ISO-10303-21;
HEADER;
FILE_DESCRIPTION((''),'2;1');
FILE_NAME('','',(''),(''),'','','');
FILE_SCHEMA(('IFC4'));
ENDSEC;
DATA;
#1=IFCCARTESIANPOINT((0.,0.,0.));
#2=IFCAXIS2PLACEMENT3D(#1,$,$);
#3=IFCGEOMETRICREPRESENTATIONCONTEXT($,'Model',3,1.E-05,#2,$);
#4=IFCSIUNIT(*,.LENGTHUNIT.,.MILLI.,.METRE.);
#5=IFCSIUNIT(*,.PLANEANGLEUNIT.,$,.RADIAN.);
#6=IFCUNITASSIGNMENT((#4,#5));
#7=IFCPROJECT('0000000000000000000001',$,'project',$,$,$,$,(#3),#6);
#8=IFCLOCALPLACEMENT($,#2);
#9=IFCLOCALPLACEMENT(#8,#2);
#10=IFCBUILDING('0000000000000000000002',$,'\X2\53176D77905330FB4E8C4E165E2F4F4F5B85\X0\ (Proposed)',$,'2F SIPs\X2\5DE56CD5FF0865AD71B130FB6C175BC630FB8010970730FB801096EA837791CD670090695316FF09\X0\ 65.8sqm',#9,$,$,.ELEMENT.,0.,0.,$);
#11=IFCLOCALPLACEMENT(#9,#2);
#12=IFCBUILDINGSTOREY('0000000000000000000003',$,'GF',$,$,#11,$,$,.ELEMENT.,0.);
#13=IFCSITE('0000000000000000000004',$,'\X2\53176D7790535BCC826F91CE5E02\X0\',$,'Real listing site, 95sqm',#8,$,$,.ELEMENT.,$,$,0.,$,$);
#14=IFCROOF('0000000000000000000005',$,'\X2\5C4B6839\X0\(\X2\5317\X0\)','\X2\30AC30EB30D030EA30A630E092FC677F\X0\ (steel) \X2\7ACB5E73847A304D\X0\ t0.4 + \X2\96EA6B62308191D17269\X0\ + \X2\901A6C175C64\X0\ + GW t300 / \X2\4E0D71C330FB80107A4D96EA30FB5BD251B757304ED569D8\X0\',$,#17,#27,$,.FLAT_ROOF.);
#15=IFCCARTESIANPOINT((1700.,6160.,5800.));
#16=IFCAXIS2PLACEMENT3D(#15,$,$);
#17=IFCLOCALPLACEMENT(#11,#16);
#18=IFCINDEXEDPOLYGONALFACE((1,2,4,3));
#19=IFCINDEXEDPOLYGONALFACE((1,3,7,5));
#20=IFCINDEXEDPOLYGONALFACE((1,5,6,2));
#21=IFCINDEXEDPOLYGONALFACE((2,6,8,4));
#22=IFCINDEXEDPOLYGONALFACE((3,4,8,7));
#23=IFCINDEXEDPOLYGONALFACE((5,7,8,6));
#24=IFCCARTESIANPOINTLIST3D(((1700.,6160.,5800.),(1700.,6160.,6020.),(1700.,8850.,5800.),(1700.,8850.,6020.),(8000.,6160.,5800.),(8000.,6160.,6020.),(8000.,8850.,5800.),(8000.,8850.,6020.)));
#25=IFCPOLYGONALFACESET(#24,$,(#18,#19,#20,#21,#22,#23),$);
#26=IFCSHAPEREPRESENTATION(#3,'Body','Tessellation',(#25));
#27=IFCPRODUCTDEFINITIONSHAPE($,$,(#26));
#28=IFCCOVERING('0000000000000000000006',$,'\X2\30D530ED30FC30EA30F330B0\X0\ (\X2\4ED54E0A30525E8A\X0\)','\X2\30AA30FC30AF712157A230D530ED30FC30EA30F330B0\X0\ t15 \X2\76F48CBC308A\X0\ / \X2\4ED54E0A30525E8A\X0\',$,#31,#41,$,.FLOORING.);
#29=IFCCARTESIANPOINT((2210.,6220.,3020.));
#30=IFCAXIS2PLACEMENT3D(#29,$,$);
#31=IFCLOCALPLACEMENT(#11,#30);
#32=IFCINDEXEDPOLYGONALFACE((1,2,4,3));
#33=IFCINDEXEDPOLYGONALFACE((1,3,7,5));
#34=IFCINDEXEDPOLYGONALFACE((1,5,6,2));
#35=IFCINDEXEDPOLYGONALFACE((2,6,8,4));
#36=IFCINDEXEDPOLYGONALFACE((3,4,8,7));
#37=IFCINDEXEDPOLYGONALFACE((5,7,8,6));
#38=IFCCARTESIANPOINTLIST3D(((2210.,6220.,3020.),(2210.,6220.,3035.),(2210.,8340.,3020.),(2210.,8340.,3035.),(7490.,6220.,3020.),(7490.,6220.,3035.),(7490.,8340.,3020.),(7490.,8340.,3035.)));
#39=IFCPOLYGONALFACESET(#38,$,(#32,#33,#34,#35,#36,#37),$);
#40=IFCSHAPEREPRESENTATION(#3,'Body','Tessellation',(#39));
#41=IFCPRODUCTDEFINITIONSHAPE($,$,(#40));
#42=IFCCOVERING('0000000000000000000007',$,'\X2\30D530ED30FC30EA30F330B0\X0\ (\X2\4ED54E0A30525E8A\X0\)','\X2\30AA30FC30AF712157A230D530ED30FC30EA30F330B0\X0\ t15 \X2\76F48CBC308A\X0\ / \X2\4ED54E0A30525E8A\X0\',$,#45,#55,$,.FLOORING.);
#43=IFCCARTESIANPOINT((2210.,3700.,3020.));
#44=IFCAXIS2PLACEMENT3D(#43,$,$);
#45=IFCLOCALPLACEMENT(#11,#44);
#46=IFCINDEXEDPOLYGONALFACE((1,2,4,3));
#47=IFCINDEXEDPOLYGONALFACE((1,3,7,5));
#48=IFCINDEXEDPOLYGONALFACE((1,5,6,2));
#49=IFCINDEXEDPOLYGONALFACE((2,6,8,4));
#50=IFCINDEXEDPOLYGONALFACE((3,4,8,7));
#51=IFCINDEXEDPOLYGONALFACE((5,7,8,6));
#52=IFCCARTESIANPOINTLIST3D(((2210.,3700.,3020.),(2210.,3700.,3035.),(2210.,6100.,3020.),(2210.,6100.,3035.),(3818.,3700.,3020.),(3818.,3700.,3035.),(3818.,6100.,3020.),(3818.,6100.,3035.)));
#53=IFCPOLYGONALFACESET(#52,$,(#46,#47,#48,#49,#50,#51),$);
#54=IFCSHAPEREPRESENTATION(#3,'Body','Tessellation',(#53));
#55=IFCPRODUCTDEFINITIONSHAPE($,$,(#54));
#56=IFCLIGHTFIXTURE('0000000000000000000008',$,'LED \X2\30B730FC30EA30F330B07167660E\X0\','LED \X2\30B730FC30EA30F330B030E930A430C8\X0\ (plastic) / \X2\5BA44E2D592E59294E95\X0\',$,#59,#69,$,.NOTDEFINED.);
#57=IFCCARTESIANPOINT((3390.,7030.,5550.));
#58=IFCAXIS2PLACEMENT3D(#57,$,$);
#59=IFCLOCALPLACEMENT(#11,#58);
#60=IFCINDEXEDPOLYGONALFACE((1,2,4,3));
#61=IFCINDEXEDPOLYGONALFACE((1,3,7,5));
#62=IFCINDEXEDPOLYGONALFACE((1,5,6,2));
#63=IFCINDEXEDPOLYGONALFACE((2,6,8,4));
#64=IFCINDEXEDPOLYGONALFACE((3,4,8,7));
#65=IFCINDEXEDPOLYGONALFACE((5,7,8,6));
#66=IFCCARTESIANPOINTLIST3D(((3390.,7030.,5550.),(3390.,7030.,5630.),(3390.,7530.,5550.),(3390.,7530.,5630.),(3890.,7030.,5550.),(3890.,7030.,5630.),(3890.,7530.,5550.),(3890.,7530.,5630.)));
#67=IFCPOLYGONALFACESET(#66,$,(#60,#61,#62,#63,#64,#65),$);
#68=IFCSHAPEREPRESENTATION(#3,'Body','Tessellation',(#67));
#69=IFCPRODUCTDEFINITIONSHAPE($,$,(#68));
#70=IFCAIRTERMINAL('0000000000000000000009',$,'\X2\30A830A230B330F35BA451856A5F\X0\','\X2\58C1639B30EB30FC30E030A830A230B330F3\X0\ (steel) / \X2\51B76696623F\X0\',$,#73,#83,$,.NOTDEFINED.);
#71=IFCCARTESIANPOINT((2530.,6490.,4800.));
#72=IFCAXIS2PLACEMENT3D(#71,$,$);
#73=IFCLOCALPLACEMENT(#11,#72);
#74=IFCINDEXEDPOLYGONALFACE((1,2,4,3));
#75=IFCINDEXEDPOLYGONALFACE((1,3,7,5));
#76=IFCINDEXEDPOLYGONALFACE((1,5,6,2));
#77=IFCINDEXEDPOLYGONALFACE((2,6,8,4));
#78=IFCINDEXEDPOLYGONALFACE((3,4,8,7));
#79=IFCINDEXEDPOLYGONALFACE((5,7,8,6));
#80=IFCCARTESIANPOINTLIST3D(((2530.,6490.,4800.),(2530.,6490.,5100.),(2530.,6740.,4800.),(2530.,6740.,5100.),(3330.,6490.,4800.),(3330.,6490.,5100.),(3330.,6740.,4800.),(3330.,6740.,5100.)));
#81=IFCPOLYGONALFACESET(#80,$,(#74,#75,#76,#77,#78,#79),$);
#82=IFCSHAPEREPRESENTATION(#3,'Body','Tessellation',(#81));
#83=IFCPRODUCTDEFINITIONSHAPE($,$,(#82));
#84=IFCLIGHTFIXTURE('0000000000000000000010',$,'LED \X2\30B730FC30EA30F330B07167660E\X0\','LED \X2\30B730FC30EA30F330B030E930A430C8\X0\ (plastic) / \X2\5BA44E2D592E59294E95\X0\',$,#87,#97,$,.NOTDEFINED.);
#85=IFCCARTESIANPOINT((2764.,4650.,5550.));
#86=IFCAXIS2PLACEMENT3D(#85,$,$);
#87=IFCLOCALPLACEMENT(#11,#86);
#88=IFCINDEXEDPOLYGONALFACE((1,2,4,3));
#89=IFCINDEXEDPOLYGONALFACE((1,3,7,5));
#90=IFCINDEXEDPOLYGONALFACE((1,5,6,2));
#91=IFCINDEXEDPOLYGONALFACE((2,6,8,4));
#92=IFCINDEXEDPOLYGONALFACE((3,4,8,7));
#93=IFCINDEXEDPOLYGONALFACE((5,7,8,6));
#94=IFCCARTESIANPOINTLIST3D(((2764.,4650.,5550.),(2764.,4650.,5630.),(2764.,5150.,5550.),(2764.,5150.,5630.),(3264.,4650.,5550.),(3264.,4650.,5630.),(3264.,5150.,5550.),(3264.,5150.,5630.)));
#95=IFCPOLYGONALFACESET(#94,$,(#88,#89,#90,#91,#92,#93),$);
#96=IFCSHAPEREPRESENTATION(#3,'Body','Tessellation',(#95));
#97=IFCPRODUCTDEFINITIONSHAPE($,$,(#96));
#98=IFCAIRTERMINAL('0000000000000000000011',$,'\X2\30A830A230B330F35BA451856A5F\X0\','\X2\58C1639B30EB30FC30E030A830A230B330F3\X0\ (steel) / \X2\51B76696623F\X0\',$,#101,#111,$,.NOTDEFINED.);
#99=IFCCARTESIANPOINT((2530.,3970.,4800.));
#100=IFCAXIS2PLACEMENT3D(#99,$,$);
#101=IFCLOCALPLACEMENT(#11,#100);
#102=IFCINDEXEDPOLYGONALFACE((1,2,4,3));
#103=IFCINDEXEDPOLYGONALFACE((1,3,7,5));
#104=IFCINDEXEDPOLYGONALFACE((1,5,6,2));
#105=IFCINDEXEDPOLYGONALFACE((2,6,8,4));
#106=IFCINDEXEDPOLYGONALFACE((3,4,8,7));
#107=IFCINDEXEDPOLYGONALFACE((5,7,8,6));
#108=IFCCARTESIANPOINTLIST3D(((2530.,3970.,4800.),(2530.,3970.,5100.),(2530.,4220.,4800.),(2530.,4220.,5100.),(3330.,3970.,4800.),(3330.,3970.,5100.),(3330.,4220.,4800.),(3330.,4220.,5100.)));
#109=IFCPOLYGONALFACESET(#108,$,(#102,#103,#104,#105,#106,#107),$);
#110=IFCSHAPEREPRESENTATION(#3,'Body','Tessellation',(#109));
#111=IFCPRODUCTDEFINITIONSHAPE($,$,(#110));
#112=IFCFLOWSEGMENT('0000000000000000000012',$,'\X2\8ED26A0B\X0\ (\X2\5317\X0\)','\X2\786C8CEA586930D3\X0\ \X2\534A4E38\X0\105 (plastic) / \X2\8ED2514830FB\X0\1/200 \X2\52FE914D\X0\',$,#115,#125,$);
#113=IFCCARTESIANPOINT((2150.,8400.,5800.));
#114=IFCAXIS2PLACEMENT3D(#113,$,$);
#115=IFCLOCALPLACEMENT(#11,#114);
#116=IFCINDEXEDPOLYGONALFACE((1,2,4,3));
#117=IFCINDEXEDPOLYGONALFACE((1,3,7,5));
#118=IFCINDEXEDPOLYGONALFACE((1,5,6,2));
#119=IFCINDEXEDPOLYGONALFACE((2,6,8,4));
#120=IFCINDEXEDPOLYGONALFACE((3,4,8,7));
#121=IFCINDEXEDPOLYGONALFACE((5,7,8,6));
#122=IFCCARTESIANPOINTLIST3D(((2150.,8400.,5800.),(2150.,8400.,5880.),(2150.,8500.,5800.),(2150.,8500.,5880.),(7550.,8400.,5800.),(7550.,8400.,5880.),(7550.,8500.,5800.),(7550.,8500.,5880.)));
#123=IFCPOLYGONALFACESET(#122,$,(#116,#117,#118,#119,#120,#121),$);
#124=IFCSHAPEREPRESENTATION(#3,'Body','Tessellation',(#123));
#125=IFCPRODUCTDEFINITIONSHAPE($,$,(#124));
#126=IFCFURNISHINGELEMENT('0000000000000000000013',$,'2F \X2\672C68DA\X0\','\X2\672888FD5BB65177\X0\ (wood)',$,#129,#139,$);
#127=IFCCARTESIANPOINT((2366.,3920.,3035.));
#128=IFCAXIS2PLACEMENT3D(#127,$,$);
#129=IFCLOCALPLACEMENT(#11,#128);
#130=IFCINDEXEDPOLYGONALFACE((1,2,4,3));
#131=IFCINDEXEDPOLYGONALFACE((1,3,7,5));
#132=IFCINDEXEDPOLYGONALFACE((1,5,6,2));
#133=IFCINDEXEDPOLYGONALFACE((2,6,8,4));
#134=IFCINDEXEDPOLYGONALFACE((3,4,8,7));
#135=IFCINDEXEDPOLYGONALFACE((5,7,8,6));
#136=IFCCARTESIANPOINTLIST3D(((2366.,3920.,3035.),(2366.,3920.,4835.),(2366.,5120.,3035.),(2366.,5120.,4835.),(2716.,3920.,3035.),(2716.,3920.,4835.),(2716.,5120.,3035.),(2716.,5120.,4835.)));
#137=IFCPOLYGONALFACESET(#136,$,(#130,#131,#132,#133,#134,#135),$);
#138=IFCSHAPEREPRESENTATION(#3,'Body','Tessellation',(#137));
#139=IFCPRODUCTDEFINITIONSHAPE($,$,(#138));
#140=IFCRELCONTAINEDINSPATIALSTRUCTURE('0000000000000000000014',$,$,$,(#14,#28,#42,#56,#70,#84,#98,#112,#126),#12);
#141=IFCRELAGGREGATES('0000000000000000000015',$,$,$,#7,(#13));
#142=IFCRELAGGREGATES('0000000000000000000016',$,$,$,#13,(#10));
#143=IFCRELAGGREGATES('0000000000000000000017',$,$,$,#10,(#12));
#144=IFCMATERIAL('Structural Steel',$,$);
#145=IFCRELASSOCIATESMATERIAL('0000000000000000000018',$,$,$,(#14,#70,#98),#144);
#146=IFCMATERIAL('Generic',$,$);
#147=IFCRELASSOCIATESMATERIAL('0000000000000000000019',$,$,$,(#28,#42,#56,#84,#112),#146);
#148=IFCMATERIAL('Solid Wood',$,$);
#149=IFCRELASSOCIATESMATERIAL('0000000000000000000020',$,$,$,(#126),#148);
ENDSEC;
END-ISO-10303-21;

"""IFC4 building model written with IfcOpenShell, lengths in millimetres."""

from ifc_helpers import new_model, si_unit, frame, frame_2d, origin, place, context, project, spatial, rectangle, extrude, material, element, save


model = new_model("IFC4")

# Units and contexts
model_context = context("Model", 3, precision=1e-05, world=origin())
ifc_project = project(units=[si_unit("LENGTHUNIT", "METRE", prefix="MILLI"), si_unit("PLANEANGLEUNIT", "RADIAN")], contexts=[model_context])

# Site, building, storey
site_placement = place(None, origin())
site = spatial("IfcSite", under=ifc_project, at=site_placement, Name="北海道富良野市", ObjectType="Real listing site, 95sqm", CompositionType="ELEMENT", RefElevation=0.0)
building_placement = place(site_placement, origin())
building = spatial("IfcBuilding", under=site, at=building_placement, Name="北海道・二世帯住宅 (Proposed)", ObjectType="2F SIPs工法（断熱・気密・耐震・耐雪荷重最適化） 65.8sqm", CompositionType="ELEMENT", ElevationOfRefHeight=0.0, ElevationOfTerrain=0.0)
storey_placement = place(building_placement, origin())
storey = spatial("IfcBuildingStorey", under=building, at=storey_placement, Name="GF", CompositionType="ELEMENT", Elevation=0.0)

# Shared definitions
ifc_material_1 = material(Name="Solid Wood")

# Roof
ifc_material_2 = material(Name="Structural Steel")
for number, where, name in (
    (1, (1700.0, 6160.0, 5800.0), "屋根(北)"),
):
    element("IfcRoof", number, at=place(storey_placement, frame(where)), inside=storey, material=ifc_material_2, Name=name, Description="ガルバリウム鋼板 (steel) 立平葺き t0.4 + 雪止め金物 + 通気層 + GW t300 / 不燃・耐積雪・寒冷地仕様", PredefinedType="FLAT_ROOF", context=model_context, shape_type="SweptSolid", body=[
        extrude(rectangle(XDim=6300.0, YDim=2690.0, at=frame_2d((3150.0, 1345.0))), frame((1700.0, 6160.0, 5800.0)), (0.0, 0.0, 1.0), 220.0),
    ])

# Coverings
ifc_material_3 = material(Name="Generic")
covering_1_placement = place(storey_placement, frame((2210.0, 6220.0, 3020.0)))
element("IfcCovering", 2, at=covering_1_placement, inside=storey, material=ifc_material_3, Name="フローリング (仕上げ床)", Description="オーク無垢フローリング t15 直貼り / 仕上げ床", PredefinedType="FLOORING", context=model_context, shape_type="SweptSolid", body=[
    extrude(rectangle(XDim=5280.0, YDim=2120.0, at=frame_2d((2640.0, 1060.0))), frame((2210.0, 6220.0, 3020.0)), (0.0, 0.0, 1.0), 15.0),
])
covering_2_placement = place(storey_placement, frame((2210.0, 3700.0, 3020.0)))
element("IfcCovering", 3, at=covering_2_placement, inside=storey, material=ifc_material_3, Name="フローリング (仕上げ床)", Description="オーク無垢フローリング t15 直貼り / 仕上げ床", PredefinedType="FLOORING", context=model_context, shape_type="SweptSolid", body=[
    extrude(rectangle(XDim=1608.0, YDim=2400.0, at=frame_2d((804.0, 1200.0))), frame((2210.0, 3700.0, 3020.0)), (0.0, 0.0, 1.0), 15.0),
])

# Light fixture
light_fixture_1_placement = place(storey_placement, frame((3390.0, 7030.0, 5550.0)))
element("IfcLightFixture", 4, at=light_fixture_1_placement, inside=storey, material=ifc_material_3, Name="LED シーリング照明", Description="LED シーリングライト (plastic) / 室中央天井", PredefinedType="NOTDEFINED", context=model_context, shape_type="SweptSolid", body=[
    extrude(rectangle(XDim=500.0, YDim=500.0, at=frame_2d((250.0, 250.0))), frame((3390.0, 7030.0, 5550.0)), (0.0, 0.0, 1.0), 80.0),
])

# Air terminal
air_terminal_1_placement = place(storey_placement, frame((2530.0, 6490.0, 4800.0)))
element("IfcAirTerminal", 5, at=air_terminal_1_placement, inside=storey, material=ifc_material_2, Name="エアコン室内機", Description="壁掛ルームエアコン (steel) / 冷暖房", PredefinedType="NOTDEFINED", context=model_context, shape_type="SweptSolid", body=[
    extrude(rectangle(XDim=800.0, YDim=250.0, at=frame_2d((400.0, 125.0))), frame((2530.0, 6490.0, 4800.0)), (0.0, 0.0, 1.0), 300.0),
])

# Light fixture
light_fixture_2_placement = place(storey_placement, frame((2764.0, 4650.0, 5550.0)))
element("IfcLightFixture", 6, at=light_fixture_2_placement, inside=storey, material=ifc_material_3, Name="LED シーリング照明", Description="LED シーリングライト (plastic) / 室中央天井", PredefinedType="NOTDEFINED", context=model_context, shape_type="SweptSolid", body=[
    extrude(rectangle(XDim=500.0, YDim=500.0, at=frame_2d((250.0, 250.0))), frame((2764.0, 4650.0, 5550.0)), (0.0, 0.0, 1.0), 80.0),
])

# Air terminal
air_terminal_2_placement = place(storey_placement, frame((2530.0, 3970.0, 4800.0)))
element("IfcAirTerminal", 7, at=air_terminal_2_placement, inside=storey, material=ifc_material_2, Name="エアコン室内機", Description="壁掛ルームエアコン (steel) / 冷暖房", PredefinedType="NOTDEFINED", context=model_context, shape_type="SweptSolid", body=[
    extrude(rectangle(XDim=800.0, YDim=250.0, at=frame_2d((400.0, 125.0))), frame((2530.0, 3970.0, 4800.0)), (0.0, 0.0, 1.0), 300.0),
])

# Flow segment
flow_segment_placement = place(storey_placement, frame((2150.0, 8400.0, 5800.0)))
element("IfcFlowSegment", 8, at=flow_segment_placement, inside=storey, material=ifc_material_3, Name="軒樋 (北)", Description="硬質塩ビ 半丸105 (plastic) / 軒先・1/200 勾配", context=model_context, shape_type="SweptSolid", body=[
    extrude(rectangle(XDim=5400.0, YDim=100.0, at=frame_2d((2700.0, 50.0))), frame((2150.0, 8400.0, 5800.0)), (0.0, 0.0, 1.0), 80.0),
])

# Furnishing element
furnishing_placement = place(storey_placement, frame((2366.0, 3920.0, 3035.0)))
element("IfcFurnishingElement", 9, at=furnishing_placement, inside=storey, material=ifc_material_1, Name="2F 本棚", Description="木製家具 (wood)", context=model_context, shape_type="SweptSolid", body=[
    extrude(rectangle(XDim=350.0, YDim=1200.0, at=frame_2d((175.0, 600.0))), frame((2366.0, 3920.0, 3035.0)), (0.0, 0.0, 1.0), 1800.0),
])

save(model, "model.ifc")
